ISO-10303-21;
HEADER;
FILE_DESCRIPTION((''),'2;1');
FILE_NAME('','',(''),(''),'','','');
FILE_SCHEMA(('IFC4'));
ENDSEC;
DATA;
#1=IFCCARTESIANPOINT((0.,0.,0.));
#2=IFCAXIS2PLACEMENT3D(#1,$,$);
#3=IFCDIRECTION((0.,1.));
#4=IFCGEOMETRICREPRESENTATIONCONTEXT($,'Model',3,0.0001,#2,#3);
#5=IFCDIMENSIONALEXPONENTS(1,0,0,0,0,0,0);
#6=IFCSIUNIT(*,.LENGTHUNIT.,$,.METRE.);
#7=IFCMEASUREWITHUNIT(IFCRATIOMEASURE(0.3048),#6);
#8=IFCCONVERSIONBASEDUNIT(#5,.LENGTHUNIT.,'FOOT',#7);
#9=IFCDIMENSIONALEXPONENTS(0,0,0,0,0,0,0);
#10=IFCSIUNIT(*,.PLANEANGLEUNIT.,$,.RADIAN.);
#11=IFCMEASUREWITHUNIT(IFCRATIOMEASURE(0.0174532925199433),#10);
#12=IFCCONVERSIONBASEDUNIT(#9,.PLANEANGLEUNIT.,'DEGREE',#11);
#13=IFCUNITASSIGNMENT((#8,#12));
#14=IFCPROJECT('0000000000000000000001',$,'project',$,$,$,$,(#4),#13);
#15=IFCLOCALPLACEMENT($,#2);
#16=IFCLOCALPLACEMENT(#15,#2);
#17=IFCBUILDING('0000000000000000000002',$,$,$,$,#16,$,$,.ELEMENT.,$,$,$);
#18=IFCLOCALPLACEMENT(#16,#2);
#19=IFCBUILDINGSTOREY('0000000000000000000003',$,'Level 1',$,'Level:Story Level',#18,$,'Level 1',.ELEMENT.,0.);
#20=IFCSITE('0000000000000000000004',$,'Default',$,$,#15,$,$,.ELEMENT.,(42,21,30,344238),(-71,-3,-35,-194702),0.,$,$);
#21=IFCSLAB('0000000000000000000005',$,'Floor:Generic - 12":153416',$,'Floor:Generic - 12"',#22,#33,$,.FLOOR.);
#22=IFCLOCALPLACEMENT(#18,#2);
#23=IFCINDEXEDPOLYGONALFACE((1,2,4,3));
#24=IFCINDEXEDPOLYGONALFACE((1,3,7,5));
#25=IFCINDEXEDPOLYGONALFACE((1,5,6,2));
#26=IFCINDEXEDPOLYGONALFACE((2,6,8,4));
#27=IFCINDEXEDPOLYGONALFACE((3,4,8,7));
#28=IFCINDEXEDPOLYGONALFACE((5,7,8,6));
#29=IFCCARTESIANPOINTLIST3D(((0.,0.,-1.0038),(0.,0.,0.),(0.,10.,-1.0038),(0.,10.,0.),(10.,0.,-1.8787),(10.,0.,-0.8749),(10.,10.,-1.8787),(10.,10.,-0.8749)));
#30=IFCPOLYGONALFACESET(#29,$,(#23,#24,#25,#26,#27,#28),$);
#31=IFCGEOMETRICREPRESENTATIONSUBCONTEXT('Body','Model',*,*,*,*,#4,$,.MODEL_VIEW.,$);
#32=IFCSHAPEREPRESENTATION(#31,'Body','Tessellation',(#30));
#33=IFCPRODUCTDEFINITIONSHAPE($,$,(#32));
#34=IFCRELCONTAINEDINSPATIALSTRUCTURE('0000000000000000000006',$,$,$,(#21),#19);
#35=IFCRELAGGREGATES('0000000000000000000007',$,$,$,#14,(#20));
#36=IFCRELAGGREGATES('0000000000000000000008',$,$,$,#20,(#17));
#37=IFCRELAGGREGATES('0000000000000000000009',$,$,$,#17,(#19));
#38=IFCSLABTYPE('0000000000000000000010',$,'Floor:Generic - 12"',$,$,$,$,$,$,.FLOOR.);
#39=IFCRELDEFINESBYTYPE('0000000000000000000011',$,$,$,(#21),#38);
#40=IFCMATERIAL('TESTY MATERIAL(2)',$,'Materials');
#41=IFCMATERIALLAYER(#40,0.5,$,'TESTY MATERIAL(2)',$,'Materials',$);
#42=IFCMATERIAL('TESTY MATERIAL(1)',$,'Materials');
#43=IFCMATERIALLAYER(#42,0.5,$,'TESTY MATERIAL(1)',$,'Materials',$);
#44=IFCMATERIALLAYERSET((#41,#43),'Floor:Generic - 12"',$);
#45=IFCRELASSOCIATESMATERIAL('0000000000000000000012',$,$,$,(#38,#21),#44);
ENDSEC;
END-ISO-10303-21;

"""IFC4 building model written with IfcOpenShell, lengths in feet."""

from ifc_helpers import new_model, entity, si_unit, converted_unit, direction, frame, frame_2d, origin, place, context, subcontext, project, spatial, rectangle, extrude, clip, halfspace, material, layer, layer_set, layer_usage, type_object, element, save


model = new_model("IFC4")

# Units and contexts
model_context = context("Model", 3, precision=0.0001, world=origin(), true_north=direction((0.0, 1.0)))
body_context = subcontext(model_context, "Body", "Model", "MODEL_VIEW")
ifc_project = project(units=[converted_unit("LENGTHUNIT", "FOOT", entity("IfcRatioMeasure", 0.3048), si_unit("LENGTHUNIT", "METRE"), dimensions=[1, 0, 0, 0, 0, 0, 0]), converted_unit("PLANEANGLEUNIT", "DEGREE", entity("IfcRatioMeasure", 0.0174532925199433), si_unit("PLANEANGLEUNIT", "RADIAN"), dimensions=[0, 0, 0, 0, 0, 0, 0])], contexts=[model_context])

# Site, building, storey
site_placement = place(None, origin())
site = spatial("IfcSite", under=ifc_project, at=site_placement, Name="Default", CompositionType="ELEMENT", RefLatitude=(42, 21, 30, 344238), RefLongitude=(-71, -3, -35, -194702), RefElevation=0.0)
building_placement = place(site_placement, origin())
building = spatial("IfcBuilding", under=site, at=building_placement, CompositionType="ELEMENT")
storey_placement = place(building_placement, origin())
storey = spatial("IfcBuildingStorey", under=building, at=storey_placement, Name="Level 1", ObjectType="Level:Story Level", LongName="Level 1", CompositionType="ELEMENT", Elevation=0.0)

# Slab
ifc_material_1 = material(Name="TESTY MATERIAL(2)", Category="Materials")
ifc_layer_1 = layer(ifc_material_1, 0.5, Name="TESTY MATERIAL(2)", Category="Materials")
ifc_material_2 = material(Name="TESTY MATERIAL(1)", Category="Materials")
ifc_layer_2 = layer(ifc_material_2, 0.5, Name="TESTY MATERIAL(1)", Category="Materials")
ifc_layer_set = layer_set([ifc_layer_1, ifc_layer_2], Name="Floor:Generic - 12\"")
ifc_layer_usage = layer_usage(ifc_layer_set, "AXIS3", "POSITIVE", 0.0)
slab_type = type_object("IfcSlabType", Name="Floor:Generic - 12\"", PredefinedType="FLOOR", material=ifc_layer_set)
slab_placement = place(storey_placement, origin())
element("IfcSlab", 1, at=slab_placement, inside=storey, type_object=slab_type, material=ifc_layer_usage, Name="Floor:Generic - 12\":153416", ObjectType="Floor:Generic - 12\"", PredefinedType="FLOOR", context=body_context, shape_type="Clipping", body=[
    clip(clip(extrude(rectangle(XDim=10.0382, YDim=10.0, at=frame_2d((0.0, 0.0), x_axis=(0.0, 1.0))), frame((5.0, 5.0, -0.4374), z_axis=(-0.087156, 0.0, -0.996195), x_axis=(0.0, 1.0, 0.0)), (0.0, 0.087156, 0.996195), 1.0077), halfspace(frame((0.0, 10.0, -1.0038), z_axis=(-0.087156, 0.0, -0.996195), x_axis=(-0.996195, 0.0, 0.087156)), False)), halfspace(frame((0.0, 10.0, 0.0), z_axis=(0.087156, 0.0, 0.996195), x_axis=(0.996195, 0.0, -0.087156)), False)),
])

save(model, "model.ifc")
